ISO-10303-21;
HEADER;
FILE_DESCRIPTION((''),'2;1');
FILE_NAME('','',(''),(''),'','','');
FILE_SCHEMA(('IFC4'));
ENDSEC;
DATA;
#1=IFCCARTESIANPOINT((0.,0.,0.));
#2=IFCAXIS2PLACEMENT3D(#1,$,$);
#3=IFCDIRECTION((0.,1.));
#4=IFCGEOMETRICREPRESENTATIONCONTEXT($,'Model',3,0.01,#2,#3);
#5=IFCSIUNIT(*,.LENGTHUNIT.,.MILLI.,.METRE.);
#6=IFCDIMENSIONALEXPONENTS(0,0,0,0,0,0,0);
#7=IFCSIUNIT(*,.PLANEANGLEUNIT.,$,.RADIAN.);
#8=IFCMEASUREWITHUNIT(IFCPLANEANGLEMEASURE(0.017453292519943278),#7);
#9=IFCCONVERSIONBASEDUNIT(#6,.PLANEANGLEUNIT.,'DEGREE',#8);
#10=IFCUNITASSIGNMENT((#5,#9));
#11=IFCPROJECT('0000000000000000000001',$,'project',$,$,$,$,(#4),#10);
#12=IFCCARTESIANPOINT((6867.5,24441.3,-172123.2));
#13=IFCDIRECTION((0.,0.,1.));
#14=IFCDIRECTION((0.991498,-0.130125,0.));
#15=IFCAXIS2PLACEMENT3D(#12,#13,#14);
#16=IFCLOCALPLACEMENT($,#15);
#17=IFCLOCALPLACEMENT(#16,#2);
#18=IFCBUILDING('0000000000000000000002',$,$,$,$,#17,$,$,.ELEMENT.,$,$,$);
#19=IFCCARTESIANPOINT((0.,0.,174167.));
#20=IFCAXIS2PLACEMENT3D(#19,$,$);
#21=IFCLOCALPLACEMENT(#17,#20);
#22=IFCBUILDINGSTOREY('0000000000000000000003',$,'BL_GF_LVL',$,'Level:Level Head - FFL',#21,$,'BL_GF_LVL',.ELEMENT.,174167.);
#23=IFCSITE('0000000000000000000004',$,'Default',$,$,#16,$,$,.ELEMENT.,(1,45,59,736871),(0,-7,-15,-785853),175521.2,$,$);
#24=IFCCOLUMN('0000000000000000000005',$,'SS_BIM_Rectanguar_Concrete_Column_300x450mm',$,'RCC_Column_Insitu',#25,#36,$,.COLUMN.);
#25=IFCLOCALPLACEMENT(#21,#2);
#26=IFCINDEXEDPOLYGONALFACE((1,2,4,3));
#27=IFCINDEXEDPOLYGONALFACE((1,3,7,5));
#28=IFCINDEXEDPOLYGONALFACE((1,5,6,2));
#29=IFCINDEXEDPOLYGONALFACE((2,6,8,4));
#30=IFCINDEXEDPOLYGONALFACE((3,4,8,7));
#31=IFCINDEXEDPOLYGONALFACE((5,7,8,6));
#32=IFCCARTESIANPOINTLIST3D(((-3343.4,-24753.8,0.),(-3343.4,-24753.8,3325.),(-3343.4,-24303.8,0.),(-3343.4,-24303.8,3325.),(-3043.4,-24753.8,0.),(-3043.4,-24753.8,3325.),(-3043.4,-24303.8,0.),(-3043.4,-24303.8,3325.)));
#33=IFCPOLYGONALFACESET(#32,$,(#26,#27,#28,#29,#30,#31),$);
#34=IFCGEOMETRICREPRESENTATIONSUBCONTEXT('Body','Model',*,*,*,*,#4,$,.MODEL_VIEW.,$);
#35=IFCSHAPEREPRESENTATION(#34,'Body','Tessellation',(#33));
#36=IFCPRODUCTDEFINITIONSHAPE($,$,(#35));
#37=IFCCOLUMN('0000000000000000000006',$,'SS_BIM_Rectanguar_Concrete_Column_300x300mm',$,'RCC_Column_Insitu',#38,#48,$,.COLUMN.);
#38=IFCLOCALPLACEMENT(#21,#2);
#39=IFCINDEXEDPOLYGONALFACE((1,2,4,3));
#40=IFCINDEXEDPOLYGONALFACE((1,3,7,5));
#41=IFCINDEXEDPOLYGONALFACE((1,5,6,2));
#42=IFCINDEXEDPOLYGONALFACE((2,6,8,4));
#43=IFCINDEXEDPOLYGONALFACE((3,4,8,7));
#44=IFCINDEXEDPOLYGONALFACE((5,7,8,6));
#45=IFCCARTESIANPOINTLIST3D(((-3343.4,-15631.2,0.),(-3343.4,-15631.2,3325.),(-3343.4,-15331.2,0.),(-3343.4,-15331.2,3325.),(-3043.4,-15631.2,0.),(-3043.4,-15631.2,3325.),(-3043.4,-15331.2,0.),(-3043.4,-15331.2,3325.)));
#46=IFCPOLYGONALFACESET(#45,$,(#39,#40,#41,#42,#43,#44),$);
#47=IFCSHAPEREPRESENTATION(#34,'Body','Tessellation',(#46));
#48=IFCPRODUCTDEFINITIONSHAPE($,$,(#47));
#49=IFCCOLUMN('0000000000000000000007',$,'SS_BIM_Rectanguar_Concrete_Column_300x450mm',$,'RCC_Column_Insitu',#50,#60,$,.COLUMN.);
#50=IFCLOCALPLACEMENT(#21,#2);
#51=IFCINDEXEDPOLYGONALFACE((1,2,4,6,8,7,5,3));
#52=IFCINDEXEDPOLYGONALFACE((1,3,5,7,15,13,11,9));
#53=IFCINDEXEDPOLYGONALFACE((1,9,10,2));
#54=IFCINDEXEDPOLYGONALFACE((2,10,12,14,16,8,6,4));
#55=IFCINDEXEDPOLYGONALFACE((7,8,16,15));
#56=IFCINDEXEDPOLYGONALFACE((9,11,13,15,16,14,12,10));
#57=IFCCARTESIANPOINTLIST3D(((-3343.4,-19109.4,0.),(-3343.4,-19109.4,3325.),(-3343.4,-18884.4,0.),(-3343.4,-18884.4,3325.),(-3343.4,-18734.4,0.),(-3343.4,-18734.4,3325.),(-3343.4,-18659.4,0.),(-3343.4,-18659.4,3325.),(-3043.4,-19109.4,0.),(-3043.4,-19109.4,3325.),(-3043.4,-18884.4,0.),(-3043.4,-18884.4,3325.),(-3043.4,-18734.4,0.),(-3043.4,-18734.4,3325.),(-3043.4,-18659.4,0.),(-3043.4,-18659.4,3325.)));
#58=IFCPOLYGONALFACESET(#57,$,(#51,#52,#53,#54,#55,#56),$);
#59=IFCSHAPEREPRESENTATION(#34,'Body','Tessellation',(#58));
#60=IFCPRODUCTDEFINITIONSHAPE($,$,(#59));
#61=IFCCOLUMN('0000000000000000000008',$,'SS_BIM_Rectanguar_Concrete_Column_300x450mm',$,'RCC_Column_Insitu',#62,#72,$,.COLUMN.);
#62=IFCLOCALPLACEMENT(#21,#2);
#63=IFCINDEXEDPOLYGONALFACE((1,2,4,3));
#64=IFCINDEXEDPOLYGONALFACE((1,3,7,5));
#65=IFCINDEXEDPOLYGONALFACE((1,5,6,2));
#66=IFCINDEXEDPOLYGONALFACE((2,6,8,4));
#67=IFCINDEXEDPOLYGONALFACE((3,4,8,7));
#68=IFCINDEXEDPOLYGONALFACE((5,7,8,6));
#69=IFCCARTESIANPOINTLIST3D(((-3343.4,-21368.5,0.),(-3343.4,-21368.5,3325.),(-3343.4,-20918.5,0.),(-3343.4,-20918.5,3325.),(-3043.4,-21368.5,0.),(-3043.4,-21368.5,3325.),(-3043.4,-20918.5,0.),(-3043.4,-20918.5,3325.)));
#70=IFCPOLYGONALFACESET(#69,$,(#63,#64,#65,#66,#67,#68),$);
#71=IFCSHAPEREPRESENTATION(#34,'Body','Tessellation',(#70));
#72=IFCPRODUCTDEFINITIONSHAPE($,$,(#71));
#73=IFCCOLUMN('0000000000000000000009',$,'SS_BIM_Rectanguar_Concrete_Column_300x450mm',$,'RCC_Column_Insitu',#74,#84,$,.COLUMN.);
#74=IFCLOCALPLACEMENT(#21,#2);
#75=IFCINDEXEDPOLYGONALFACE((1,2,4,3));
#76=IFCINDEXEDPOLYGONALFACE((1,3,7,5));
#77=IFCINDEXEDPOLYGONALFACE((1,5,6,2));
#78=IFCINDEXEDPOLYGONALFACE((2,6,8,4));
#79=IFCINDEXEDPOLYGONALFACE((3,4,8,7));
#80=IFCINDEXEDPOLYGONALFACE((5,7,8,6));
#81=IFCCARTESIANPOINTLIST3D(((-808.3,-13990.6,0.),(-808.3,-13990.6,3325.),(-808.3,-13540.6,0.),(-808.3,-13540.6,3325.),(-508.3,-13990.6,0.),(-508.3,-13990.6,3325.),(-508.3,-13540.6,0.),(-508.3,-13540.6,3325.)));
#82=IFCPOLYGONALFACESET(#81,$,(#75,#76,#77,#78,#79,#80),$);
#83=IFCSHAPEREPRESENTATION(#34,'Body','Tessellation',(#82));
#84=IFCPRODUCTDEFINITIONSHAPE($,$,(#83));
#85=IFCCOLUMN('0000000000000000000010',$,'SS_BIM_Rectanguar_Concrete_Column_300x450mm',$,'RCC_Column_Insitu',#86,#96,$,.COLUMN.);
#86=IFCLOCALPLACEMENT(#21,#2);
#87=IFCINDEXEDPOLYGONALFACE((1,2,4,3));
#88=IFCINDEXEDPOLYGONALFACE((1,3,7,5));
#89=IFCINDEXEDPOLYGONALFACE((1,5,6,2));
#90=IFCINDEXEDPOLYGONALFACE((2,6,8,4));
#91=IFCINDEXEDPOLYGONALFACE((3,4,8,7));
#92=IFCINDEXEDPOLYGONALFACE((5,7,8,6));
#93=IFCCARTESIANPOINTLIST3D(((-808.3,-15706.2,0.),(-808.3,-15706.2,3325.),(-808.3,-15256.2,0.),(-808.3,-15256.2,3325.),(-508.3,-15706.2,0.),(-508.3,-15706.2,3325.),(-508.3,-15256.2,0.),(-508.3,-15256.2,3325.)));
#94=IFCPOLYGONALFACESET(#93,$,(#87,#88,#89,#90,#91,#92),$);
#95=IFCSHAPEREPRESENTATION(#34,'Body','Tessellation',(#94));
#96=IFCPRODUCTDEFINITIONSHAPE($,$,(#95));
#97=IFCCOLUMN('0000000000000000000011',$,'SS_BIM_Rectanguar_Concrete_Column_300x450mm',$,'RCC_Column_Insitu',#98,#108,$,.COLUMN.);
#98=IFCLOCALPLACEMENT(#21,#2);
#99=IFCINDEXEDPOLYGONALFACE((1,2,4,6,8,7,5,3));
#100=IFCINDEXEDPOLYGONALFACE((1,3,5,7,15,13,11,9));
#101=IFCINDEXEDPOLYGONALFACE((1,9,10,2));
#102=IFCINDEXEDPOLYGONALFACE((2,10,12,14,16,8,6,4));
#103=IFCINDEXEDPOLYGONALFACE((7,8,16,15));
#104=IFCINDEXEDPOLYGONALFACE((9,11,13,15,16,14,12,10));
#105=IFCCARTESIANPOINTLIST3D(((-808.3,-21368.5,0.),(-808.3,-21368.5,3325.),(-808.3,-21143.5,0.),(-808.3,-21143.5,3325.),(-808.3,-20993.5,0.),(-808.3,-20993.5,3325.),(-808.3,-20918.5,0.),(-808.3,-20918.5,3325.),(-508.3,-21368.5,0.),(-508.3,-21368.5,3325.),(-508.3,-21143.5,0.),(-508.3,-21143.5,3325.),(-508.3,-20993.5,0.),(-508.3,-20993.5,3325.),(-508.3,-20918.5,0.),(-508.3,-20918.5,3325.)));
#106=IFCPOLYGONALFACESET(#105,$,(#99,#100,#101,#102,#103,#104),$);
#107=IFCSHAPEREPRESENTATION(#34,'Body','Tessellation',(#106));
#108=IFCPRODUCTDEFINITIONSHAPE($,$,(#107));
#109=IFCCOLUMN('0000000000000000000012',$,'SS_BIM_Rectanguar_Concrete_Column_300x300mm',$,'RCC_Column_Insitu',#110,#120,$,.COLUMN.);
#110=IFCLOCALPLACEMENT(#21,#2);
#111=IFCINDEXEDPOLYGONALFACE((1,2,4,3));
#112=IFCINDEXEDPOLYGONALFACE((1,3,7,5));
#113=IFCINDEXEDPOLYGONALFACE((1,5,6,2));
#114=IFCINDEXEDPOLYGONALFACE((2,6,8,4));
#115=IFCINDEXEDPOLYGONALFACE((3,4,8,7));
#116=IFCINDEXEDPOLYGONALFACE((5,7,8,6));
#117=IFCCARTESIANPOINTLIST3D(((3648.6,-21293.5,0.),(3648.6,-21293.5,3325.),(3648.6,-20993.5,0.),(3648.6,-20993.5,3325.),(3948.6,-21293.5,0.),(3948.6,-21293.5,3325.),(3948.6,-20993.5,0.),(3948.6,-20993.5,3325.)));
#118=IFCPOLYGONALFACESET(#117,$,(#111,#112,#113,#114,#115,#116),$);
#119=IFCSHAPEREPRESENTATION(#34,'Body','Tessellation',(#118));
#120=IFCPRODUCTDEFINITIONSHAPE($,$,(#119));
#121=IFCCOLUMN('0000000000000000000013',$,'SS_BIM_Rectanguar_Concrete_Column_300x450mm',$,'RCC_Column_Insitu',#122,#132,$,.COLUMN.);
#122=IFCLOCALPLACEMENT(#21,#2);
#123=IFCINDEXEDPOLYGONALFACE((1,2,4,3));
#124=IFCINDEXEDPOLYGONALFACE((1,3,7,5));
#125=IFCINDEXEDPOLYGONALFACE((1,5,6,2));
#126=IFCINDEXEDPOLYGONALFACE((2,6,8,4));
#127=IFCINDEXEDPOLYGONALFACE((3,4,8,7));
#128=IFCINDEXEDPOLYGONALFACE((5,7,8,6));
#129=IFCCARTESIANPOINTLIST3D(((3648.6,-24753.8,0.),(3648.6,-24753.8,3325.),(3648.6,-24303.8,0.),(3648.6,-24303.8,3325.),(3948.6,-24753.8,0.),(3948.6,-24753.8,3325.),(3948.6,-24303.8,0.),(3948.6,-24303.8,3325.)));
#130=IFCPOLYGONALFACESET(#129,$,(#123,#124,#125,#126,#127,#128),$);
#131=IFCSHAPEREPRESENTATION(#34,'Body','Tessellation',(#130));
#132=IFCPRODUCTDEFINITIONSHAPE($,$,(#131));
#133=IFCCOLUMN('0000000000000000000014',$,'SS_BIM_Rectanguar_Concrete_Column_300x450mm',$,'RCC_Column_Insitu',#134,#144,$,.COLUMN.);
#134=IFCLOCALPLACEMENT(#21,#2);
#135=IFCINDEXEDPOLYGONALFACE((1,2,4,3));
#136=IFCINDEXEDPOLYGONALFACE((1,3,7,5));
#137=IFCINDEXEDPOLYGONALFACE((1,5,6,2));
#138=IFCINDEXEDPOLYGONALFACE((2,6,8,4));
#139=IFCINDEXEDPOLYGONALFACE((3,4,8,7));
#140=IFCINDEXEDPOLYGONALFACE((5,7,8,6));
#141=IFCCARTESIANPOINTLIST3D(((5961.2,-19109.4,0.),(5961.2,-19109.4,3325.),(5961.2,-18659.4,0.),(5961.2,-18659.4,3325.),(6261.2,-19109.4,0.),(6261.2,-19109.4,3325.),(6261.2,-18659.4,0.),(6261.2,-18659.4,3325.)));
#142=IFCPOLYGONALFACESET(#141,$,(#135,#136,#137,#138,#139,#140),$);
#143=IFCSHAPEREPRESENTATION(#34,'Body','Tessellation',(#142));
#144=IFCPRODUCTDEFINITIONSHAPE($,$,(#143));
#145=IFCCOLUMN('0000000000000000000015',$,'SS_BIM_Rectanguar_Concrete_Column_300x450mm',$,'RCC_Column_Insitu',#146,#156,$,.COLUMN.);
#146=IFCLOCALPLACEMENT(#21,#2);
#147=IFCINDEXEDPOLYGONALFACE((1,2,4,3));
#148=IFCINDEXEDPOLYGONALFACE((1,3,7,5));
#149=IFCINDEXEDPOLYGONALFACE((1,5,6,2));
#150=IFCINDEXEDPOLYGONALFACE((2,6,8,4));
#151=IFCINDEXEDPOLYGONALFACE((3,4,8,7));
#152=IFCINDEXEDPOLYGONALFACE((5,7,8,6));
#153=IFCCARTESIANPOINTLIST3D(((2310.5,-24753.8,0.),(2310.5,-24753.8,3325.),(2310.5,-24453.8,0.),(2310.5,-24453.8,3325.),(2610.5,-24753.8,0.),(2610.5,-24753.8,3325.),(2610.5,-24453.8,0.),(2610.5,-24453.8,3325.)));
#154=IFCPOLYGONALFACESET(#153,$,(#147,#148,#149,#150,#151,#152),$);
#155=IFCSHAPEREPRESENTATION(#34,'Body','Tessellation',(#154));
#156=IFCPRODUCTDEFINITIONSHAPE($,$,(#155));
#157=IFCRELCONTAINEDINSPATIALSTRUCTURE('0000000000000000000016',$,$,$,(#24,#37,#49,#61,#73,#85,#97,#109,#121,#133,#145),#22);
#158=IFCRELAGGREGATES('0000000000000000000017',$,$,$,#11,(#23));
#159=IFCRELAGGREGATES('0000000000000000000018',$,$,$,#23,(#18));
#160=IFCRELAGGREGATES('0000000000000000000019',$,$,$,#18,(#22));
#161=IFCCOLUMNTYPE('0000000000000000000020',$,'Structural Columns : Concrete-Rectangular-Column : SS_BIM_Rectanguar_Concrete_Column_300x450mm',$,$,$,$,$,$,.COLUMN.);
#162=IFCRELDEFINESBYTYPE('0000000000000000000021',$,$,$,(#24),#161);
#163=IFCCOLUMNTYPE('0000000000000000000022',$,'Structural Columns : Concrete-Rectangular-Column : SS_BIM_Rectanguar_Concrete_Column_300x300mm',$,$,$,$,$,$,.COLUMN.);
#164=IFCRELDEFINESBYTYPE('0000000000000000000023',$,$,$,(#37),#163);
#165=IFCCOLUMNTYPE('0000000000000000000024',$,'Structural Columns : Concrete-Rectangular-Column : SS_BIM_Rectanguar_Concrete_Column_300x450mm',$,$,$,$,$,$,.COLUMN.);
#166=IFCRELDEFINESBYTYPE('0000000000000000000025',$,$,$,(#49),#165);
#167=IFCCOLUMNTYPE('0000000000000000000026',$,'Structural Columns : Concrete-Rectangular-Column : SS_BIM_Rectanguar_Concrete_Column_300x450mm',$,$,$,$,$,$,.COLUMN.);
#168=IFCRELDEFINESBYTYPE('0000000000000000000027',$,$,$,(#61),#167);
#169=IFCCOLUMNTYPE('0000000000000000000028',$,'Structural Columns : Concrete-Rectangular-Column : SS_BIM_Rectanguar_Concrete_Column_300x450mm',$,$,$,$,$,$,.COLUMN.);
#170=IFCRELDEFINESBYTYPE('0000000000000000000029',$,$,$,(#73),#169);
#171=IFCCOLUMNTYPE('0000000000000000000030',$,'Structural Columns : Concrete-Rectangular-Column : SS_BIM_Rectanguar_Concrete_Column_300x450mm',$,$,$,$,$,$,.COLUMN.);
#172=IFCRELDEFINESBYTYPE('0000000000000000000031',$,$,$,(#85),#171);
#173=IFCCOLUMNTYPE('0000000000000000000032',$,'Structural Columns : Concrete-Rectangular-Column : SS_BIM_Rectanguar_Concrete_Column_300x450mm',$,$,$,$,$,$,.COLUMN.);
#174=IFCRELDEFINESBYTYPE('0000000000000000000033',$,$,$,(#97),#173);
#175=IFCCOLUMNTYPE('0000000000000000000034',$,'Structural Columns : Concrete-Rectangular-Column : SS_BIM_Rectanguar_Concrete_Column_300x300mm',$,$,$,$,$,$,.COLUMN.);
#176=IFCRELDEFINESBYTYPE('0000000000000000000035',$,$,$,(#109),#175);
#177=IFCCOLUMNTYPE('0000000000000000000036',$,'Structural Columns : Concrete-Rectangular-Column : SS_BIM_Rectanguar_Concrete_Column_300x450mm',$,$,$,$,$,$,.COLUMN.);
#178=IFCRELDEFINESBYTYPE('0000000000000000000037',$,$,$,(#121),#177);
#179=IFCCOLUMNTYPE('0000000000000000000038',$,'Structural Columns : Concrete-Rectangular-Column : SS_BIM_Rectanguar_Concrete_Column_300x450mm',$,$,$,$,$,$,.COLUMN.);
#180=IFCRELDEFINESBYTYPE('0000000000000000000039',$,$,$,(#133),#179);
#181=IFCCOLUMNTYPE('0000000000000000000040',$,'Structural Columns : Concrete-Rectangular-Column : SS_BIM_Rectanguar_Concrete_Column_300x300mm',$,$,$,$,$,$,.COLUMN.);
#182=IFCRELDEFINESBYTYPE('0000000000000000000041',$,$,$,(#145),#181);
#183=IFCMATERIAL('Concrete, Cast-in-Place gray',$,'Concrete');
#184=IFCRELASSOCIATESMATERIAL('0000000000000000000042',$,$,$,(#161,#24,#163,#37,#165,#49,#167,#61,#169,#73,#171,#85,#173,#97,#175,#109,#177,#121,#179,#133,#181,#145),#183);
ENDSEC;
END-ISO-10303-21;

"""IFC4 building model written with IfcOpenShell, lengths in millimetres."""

from ifc_helpers import new_model, entity, si_unit, converted_unit, direction, frame, origin, place, context, subcontext, project, spatial, indexed_curve, outline, extrude, source, transform, mapped, material, type_object, type_shapes, element, save


model = new_model("IFC4")

# Units and contexts
model_context = context("Model", 3, precision=0.01, world=origin(), true_north=direction((0.0, 1.0)))
body_context = subcontext(model_context, "Body", "Model", "MODEL_VIEW")
ifc_project = project(units=[si_unit("LENGTHUNIT", "METRE", prefix="MILLI"), converted_unit("PLANEANGLEUNIT", "DEGREE", entity("IfcPlaneAngleMeasure", 0.017453292519943278), si_unit("PLANEANGLEUNIT", "RADIAN"), dimensions=[0, 0, 0, 0, 0, 0, 0])], contexts=[model_context])

# Site, building, storey
site_placement = place(None, frame((6867.5, 24441.3, -172123.2), z_axis=(0.0, 0.0, 1.0), x_axis=(0.991498, -0.130125, 0.0)))
site = spatial("IfcSite", under=ifc_project, at=site_placement, Name="Default", CompositionType="ELEMENT", RefLatitude=(1, 45, 59, 736871), RefLongitude=(0, -7, -15, -785853), RefElevation=175521.2)
building_placement = place(site_placement, origin())
building = spatial("IfcBuilding", under=site, at=building_placement, CompositionType="ELEMENT")
storey_placement = place(building_placement, frame((0.0, 0.0, 174167.0)))
storey = spatial("IfcBuildingStorey", under=building, at=storey_placement, Name="BL_GF_LVL", ObjectType="Level:Level Head - FFL", LongName="BL_GF_LVL", CompositionType="ELEMENT", Elevation=174167.0)

# Columns
ifc_material_1 = material(Name="Concrete, Cast-in-Place gray", Category="Concrete")
column_type_1 = type_object("IfcColumnType", Name="Structural Columns : Concrete-Rectangular-Column : SS_BIM_Rectanguar_Concrete_Column_300x450mm", PredefinedType="COLUMN", material=ifc_material_1)
shared_shape_1 = source(origin(), body_context, "Body", "SweptSolid", [
    extrude(outline(indexed_curve([(-150.0, -225.0), (150.0, -225.0), (150.0, 225.0), (-150.0, 225.0), (-150.0, -225.0)], self_intersect=False)), frame((-3193.4, -24528.8, 174167.0), z_axis=(0.0, 0.0, 1.0), x_axis=(-1.0, 0.0, 0.0)), (0.0, 0.0, 1.0), 3325.0),
])
type_shapes(column_type_1, [shared_shape_1])
column_1_placement = place(storey_placement, frame((0.0, 0.0, -174167.0)))
element("IfcColumn", 1, at=column_1_placement, inside=storey, type_object=column_type_1, material=ifc_material_1, Name="SS_BIM_Rectanguar_Concrete_Column_300x450mm", ObjectType="RCC_Column_Insitu", PredefinedType="COLUMN", context=body_context, shape_type="MappedRepresentation", body=[
    mapped(shared_shape_1, transform((0.0, 0.0, 0.0), scale=1.0)),
])
column_type_2 = type_object("IfcColumnType", Name="Structural Columns : Concrete-Rectangular-Column : SS_BIM_Rectanguar_Concrete_Column_300x300mm", PredefinedType="COLUMN", material=ifc_material_1)
shared_shape_2 = source(origin(), body_context, "Body", "SweptSolid", [
    extrude(outline(indexed_curve([(-150.0, -150.0), (150.0, -150.0), (150.0, 150.0), (-150.0, 150.0), (-150.0, -150.0)], self_intersect=False)), frame((-3193.4, -15481.2, 174167.0), z_axis=(0.0, 0.0, 1.0), x_axis=(-1.0, 0.0, 0.0)), (0.0, 0.0, 1.0), 3325.0),
])
type_shapes(column_type_2, [shared_shape_2])
column_2_placement = place(storey_placement, frame((0.0, 0.0, -174167.0)))
element("IfcColumn", 2, at=column_2_placement, inside=storey, type_object=column_type_2, material=ifc_material_1, Name="SS_BIM_Rectanguar_Concrete_Column_300x300mm", ObjectType="RCC_Column_Insitu", PredefinedType="COLUMN", context=body_context, shape_type="MappedRepresentation", body=[
    mapped(shared_shape_2, transform((0.0, 0.0, 0.0), scale=1.0)),
])
column_type_3 = type_object("IfcColumnType", Name="Structural Columns : Concrete-Rectangular-Column : SS_BIM_Rectanguar_Concrete_Column_300x450mm", PredefinedType="COLUMN", material=ifc_material_1)
shared_shape_3 = source(origin(), body_context, "Body", "SweptSolid", [
    extrude(outline(indexed_curve([(-150.0, -187.5), (150.0, -187.5), (150.0, -112.5), (150.0, 37.5), (150.0, 262.5), (-150.0, 262.5), (-150.0, 37.5), (-150.0, -112.5), (-150.0, -187.5)], self_intersect=False)), frame((-3193.4, -18846.9, 174167.0), z_axis=(0.0, 0.0, 1.0), x_axis=(-1.0, 0.0, 0.0)), (0.0, 0.0, 1.0), 3325.0),
])
type_shapes(column_type_3, [shared_shape_3])
column_3_placement = place(storey_placement, frame((0.0, 0.0, -174167.0)))
element("IfcColumn", 3, at=column_3_placement, inside=storey, type_object=column_type_3, material=ifc_material_1, Name="SS_BIM_Rectanguar_Concrete_Column_300x450mm", ObjectType="RCC_Column_Insitu", PredefinedType="COLUMN", context=body_context, shape_type="MappedRepresentation", body=[
    mapped(shared_shape_3, transform((0.0, 0.0, 0.0), scale=1.0)),
])
column_type_4 = type_object("IfcColumnType", Name="Structural Columns : Concrete-Rectangular-Column : SS_BIM_Rectanguar_Concrete_Column_300x450mm", PredefinedType="COLUMN", material=ifc_material_1)
shared_shape_4 = source(origin(), body_context, "Body", "SweptSolid", [
    extrude(outline(indexed_curve([(-150.0, -225.0), (150.0, -225.0), (150.0, 225.0), (-150.0, 225.0), (-150.0, -225.0)], self_intersect=False)), frame((-3193.4, -21143.5, 174167.0), z_axis=(0.0, 0.0, 1.0), x_axis=(-1.0, 0.0, 0.0)), (0.0, 0.0, 1.0), 3325.0),
])
type_shapes(column_type_4, [shared_shape_4])
column_4_placement = place(storey_placement, frame((0.0, 0.0, -174167.0)))
element("IfcColumn", 4, at=column_4_placement, inside=storey, type_object=column_type_4, material=ifc_material_1, Name="SS_BIM_Rectanguar_Concrete_Column_300x450mm", ObjectType="RCC_Column_Insitu", PredefinedType="COLUMN", context=body_context, shape_type="MappedRepresentation", body=[
    mapped(shared_shape_4, transform((0.0, 0.0, 0.0), scale=1.0)),
])
column_type_5 = type_object("IfcColumnType", Name="Structural Columns : Concrete-Rectangular-Column : SS_BIM_Rectanguar_Concrete_Column_300x450mm", PredefinedType="COLUMN", material=ifc_material_1)
shared_shape_5 = source(origin(), body_context, "Body", "SweptSolid", [
    extrude(outline(indexed_curve([(-150.0, -225.0), (150.0, -225.0), (150.0, 225.0), (-150.0, 225.0), (-150.0, -225.0)], self_intersect=False)), frame((-658.3, -13765.6, 174167.0), z_axis=(0.0, 0.0, 1.0), x_axis=(-1.0, 0.0, 0.0)), (0.0, 0.0, 1.0), 3325.0),
])
type_shapes(column_type_5, [shared_shape_5])
column_5_placement = place(storey_placement, frame((0.0, 0.0, -174167.0)))
element("IfcColumn", 5, at=column_5_placement, inside=storey, type_object=column_type_5, material=ifc_material_1, Name="SS_BIM_Rectanguar_Concrete_Column_300x450mm", ObjectType="RCC_Column_Insitu", PredefinedType="COLUMN", context=body_context, shape_type="MappedRepresentation", body=[
    mapped(shared_shape_5, transform((0.0, 0.0, 0.0), scale=1.0)),
])
column_type_6 = type_object("IfcColumnType", Name="Structural Columns : Concrete-Rectangular-Column : SS_BIM_Rectanguar_Concrete_Column_300x450mm", PredefinedType="COLUMN", material=ifc_material_1)
shared_shape_6 = source(origin(), body_context, "Body", "SweptSolid", [
    extrude(outline(indexed_curve([(-150.0, -225.0), (150.0, -225.0), (150.0, 225.0), (-150.0, 225.0), (-150.0, -225.0)], self_intersect=False)), frame((-658.3, -15481.2, 174167.0), z_axis=(0.0, 0.0, 1.0), x_axis=(-1.0, 0.0, 0.0)), (0.0, 0.0, 1.0), 3325.0),
])
type_shapes(column_type_6, [shared_shape_6])
column_6_placement = place(storey_placement, frame((0.0, 0.0, -174167.0)))
element("IfcColumn", 6, at=column_6_placement, inside=storey, type_object=column_type_6, material=ifc_material_1, Name="SS_BIM_Rectanguar_Concrete_Column_300x450mm", ObjectType="RCC_Column_Insitu", PredefinedType="COLUMN", context=body_context, shape_type="MappedRepresentation", body=[
    mapped(shared_shape_6, transform((0.0, 0.0, 0.0), scale=1.0)),
])
column_type_7 = type_object("IfcColumnType", Name="Structural Columns : Concrete-Rectangular-Column : SS_BIM_Rectanguar_Concrete_Column_300x450mm", PredefinedType="COLUMN", material=ifc_material_1)
shared_shape_7 = source(origin(), body_context, "Body", "SweptSolid", [
    extrude(outline(indexed_curve([(-150.0, -187.5), (150.0, -187.5), (150.0, -112.5), (150.0, 37.5), (150.0, 262.5), (-150.0, 262.5), (-150.0, 37.5), (-150.0, -112.5), (-150.0, -187.5)], self_intersect=False)), frame((-658.3, -21106.0, 174167.0), z_axis=(0.0, 0.0, 1.0), x_axis=(-1.0, 0.0, 0.0)), (0.0, 0.0, 1.0), 3325.0),
])
type_shapes(column_type_7, [shared_shape_7])
column_7_placement = place(storey_placement, frame((0.0, 0.0, -174167.0)))
element("IfcColumn", 7, at=column_7_placement, inside=storey, type_object=column_type_7, material=ifc_material_1, Name="SS_BIM_Rectanguar_Concrete_Column_300x450mm", ObjectType="RCC_Column_Insitu", PredefinedType="COLUMN", context=body_context, shape_type="MappedRepresentation", body=[
    mapped(shared_shape_7, transform((0.0, 0.0, 0.0), scale=1.0)),
])
column_type_8 = type_object("IfcColumnType", Name="Structural Columns : Concrete-Rectangular-Column : SS_BIM_Rectanguar_Concrete_Column_300x300mm", PredefinedType="COLUMN", material=ifc_material_1)
shared_shape_8 = source(origin(), body_context, "Body", "SweptSolid", [
    extrude(outline(indexed_curve([(-150.0, -150.0), (150.0, -150.0), (150.0, 150.0), (-150.0, 150.0), (-150.0, -150.0)], self_intersect=False)), frame((3798.6, -21143.5, 174167.0), z_axis=(0.0, 0.0, 1.0), x_axis=(-1.0, 0.0, 0.0)), (0.0, 0.0, 1.0), 3325.0),
])
type_shapes(column_type_8, [shared_shape_8])
column_8_placement = place(storey_placement, frame((0.0, 0.0, -174167.0)))
element("IfcColumn", 8, at=column_8_placement, inside=storey, type_object=column_type_8, material=ifc_material_1, Name="SS_BIM_Rectanguar_Concrete_Column_300x300mm", ObjectType="RCC_Column_Insitu", PredefinedType="COLUMN", context=body_context, shape_type="MappedRepresentation", body=[
    mapped(shared_shape_8, transform((0.0, 0.0, 0.0), scale=1.0)),
])
column_type_9 = type_object("IfcColumnType", Name="Structural Columns : Concrete-Rectangular-Column : SS_BIM_Rectanguar_Concrete_Column_300x450mm", PredefinedType="COLUMN", material=ifc_material_1)
shared_shape_9 = source(origin(), body_context, "Body", "SweptSolid", [
    extrude(outline(indexed_curve([(-150.0, -225.0), (150.0, -225.0), (150.0, 225.0), (-150.0, 225.0), (-150.0, -225.0)], self_intersect=False)), frame((3798.6, -24528.8, 174167.0), z_axis=(0.0, 0.0, 1.0), x_axis=(-1.0, 0.0, 0.0)), (0.0, 0.0, 1.0), 3325.0),
])
type_shapes(column_type_9, [shared_shape_9])
column_9_placement = place(storey_placement, frame((0.0, 0.0, -174167.0)))
element("IfcColumn", 9, at=column_9_placement, inside=storey, type_object=column_type_9, material=ifc_material_1, Name="SS_BIM_Rectanguar_Concrete_Column_300x450mm", ObjectType="RCC_Column_Insitu", PredefinedType="COLUMN", context=body_context, shape_type="MappedRepresentation", body=[
    mapped(shared_shape_9, transform((0.0, 0.0, 0.0), scale=1.0)),
])
column_type_10 = type_object("IfcColumnType", Name="Structural Columns : Concrete-Rectangular-Column : SS_BIM_Rectanguar_Concrete_Column_300x450mm", PredefinedType="COLUMN", material=ifc_material_1)
shared_shape_10 = source(origin(), body_context, "Body", "SweptSolid", [
    extrude(outline(indexed_curve([(-150.0, -225.0), (150.0, -225.0), (150.0, 225.0), (-150.0, 225.0), (-150.0, -225.0)], self_intersect=False)), frame((6111.2, -18884.4, 174167.0), z_axis=(0.0, 0.0, 1.0), x_axis=(-1.0, 0.0, 0.0)), (0.0, 0.0, 1.0), 3325.0),
])
type_shapes(column_type_10, [shared_shape_10])
column_10_placement = place(storey_placement, frame((0.0, 0.0, -174167.0)))
element("IfcColumn", 10, at=column_10_placement, inside=storey, type_object=column_type_10, material=ifc_material_1, Name="SS_BIM_Rectanguar_Concrete_Column_300x450mm", ObjectType="RCC_Column_Insitu", PredefinedType="COLUMN", context=body_context, shape_type="MappedRepresentation", body=[
    mapped(shared_shape_10, transform((0.0, 0.0, 0.0), scale=1.0)),
])
column_type_11 = type_object("IfcColumnType", Name="Structural Columns : Concrete-Rectangular-Column : SS_BIM_Rectanguar_Concrete_Column_300x300mm", PredefinedType="COLUMN", material=ifc_material_1)
shared_shape_11 = source(origin(), body_context, "Body", "SweptSolid", [
    extrude(outline(indexed_curve([(-150.0, -150.0), (150.0, -150.0), (150.0, 150.0), (-150.0, 150.0), (-150.0, -150.0)], self_intersect=False)), frame((2460.5, -24603.8, 174167.0), z_axis=(0.0, 0.0, 1.0), x_axis=(-1.0, 0.0, 0.0)), (0.0, 0.0, 1.0), 3325.0),
])
type_shapes(column_type_11, [shared_shape_11])
column_11_placement = place(storey_placement, frame((0.0, 0.0, -174167.0)))
element("IfcColumn", 11, at=column_11_placement, inside=storey, type_object=column_type_11, material=ifc_material_1, Name="SS_BIM_Rectanguar_Concrete_Column_300x450mm", ObjectType="RCC_Column_Insitu", PredefinedType="COLUMN", context=body_context, shape_type="MappedRepresentation", body=[
    mapped(shared_shape_11, transform((0.0, 0.0, 0.0), scale=1.0)),
])

save(model, "model.ifc")
